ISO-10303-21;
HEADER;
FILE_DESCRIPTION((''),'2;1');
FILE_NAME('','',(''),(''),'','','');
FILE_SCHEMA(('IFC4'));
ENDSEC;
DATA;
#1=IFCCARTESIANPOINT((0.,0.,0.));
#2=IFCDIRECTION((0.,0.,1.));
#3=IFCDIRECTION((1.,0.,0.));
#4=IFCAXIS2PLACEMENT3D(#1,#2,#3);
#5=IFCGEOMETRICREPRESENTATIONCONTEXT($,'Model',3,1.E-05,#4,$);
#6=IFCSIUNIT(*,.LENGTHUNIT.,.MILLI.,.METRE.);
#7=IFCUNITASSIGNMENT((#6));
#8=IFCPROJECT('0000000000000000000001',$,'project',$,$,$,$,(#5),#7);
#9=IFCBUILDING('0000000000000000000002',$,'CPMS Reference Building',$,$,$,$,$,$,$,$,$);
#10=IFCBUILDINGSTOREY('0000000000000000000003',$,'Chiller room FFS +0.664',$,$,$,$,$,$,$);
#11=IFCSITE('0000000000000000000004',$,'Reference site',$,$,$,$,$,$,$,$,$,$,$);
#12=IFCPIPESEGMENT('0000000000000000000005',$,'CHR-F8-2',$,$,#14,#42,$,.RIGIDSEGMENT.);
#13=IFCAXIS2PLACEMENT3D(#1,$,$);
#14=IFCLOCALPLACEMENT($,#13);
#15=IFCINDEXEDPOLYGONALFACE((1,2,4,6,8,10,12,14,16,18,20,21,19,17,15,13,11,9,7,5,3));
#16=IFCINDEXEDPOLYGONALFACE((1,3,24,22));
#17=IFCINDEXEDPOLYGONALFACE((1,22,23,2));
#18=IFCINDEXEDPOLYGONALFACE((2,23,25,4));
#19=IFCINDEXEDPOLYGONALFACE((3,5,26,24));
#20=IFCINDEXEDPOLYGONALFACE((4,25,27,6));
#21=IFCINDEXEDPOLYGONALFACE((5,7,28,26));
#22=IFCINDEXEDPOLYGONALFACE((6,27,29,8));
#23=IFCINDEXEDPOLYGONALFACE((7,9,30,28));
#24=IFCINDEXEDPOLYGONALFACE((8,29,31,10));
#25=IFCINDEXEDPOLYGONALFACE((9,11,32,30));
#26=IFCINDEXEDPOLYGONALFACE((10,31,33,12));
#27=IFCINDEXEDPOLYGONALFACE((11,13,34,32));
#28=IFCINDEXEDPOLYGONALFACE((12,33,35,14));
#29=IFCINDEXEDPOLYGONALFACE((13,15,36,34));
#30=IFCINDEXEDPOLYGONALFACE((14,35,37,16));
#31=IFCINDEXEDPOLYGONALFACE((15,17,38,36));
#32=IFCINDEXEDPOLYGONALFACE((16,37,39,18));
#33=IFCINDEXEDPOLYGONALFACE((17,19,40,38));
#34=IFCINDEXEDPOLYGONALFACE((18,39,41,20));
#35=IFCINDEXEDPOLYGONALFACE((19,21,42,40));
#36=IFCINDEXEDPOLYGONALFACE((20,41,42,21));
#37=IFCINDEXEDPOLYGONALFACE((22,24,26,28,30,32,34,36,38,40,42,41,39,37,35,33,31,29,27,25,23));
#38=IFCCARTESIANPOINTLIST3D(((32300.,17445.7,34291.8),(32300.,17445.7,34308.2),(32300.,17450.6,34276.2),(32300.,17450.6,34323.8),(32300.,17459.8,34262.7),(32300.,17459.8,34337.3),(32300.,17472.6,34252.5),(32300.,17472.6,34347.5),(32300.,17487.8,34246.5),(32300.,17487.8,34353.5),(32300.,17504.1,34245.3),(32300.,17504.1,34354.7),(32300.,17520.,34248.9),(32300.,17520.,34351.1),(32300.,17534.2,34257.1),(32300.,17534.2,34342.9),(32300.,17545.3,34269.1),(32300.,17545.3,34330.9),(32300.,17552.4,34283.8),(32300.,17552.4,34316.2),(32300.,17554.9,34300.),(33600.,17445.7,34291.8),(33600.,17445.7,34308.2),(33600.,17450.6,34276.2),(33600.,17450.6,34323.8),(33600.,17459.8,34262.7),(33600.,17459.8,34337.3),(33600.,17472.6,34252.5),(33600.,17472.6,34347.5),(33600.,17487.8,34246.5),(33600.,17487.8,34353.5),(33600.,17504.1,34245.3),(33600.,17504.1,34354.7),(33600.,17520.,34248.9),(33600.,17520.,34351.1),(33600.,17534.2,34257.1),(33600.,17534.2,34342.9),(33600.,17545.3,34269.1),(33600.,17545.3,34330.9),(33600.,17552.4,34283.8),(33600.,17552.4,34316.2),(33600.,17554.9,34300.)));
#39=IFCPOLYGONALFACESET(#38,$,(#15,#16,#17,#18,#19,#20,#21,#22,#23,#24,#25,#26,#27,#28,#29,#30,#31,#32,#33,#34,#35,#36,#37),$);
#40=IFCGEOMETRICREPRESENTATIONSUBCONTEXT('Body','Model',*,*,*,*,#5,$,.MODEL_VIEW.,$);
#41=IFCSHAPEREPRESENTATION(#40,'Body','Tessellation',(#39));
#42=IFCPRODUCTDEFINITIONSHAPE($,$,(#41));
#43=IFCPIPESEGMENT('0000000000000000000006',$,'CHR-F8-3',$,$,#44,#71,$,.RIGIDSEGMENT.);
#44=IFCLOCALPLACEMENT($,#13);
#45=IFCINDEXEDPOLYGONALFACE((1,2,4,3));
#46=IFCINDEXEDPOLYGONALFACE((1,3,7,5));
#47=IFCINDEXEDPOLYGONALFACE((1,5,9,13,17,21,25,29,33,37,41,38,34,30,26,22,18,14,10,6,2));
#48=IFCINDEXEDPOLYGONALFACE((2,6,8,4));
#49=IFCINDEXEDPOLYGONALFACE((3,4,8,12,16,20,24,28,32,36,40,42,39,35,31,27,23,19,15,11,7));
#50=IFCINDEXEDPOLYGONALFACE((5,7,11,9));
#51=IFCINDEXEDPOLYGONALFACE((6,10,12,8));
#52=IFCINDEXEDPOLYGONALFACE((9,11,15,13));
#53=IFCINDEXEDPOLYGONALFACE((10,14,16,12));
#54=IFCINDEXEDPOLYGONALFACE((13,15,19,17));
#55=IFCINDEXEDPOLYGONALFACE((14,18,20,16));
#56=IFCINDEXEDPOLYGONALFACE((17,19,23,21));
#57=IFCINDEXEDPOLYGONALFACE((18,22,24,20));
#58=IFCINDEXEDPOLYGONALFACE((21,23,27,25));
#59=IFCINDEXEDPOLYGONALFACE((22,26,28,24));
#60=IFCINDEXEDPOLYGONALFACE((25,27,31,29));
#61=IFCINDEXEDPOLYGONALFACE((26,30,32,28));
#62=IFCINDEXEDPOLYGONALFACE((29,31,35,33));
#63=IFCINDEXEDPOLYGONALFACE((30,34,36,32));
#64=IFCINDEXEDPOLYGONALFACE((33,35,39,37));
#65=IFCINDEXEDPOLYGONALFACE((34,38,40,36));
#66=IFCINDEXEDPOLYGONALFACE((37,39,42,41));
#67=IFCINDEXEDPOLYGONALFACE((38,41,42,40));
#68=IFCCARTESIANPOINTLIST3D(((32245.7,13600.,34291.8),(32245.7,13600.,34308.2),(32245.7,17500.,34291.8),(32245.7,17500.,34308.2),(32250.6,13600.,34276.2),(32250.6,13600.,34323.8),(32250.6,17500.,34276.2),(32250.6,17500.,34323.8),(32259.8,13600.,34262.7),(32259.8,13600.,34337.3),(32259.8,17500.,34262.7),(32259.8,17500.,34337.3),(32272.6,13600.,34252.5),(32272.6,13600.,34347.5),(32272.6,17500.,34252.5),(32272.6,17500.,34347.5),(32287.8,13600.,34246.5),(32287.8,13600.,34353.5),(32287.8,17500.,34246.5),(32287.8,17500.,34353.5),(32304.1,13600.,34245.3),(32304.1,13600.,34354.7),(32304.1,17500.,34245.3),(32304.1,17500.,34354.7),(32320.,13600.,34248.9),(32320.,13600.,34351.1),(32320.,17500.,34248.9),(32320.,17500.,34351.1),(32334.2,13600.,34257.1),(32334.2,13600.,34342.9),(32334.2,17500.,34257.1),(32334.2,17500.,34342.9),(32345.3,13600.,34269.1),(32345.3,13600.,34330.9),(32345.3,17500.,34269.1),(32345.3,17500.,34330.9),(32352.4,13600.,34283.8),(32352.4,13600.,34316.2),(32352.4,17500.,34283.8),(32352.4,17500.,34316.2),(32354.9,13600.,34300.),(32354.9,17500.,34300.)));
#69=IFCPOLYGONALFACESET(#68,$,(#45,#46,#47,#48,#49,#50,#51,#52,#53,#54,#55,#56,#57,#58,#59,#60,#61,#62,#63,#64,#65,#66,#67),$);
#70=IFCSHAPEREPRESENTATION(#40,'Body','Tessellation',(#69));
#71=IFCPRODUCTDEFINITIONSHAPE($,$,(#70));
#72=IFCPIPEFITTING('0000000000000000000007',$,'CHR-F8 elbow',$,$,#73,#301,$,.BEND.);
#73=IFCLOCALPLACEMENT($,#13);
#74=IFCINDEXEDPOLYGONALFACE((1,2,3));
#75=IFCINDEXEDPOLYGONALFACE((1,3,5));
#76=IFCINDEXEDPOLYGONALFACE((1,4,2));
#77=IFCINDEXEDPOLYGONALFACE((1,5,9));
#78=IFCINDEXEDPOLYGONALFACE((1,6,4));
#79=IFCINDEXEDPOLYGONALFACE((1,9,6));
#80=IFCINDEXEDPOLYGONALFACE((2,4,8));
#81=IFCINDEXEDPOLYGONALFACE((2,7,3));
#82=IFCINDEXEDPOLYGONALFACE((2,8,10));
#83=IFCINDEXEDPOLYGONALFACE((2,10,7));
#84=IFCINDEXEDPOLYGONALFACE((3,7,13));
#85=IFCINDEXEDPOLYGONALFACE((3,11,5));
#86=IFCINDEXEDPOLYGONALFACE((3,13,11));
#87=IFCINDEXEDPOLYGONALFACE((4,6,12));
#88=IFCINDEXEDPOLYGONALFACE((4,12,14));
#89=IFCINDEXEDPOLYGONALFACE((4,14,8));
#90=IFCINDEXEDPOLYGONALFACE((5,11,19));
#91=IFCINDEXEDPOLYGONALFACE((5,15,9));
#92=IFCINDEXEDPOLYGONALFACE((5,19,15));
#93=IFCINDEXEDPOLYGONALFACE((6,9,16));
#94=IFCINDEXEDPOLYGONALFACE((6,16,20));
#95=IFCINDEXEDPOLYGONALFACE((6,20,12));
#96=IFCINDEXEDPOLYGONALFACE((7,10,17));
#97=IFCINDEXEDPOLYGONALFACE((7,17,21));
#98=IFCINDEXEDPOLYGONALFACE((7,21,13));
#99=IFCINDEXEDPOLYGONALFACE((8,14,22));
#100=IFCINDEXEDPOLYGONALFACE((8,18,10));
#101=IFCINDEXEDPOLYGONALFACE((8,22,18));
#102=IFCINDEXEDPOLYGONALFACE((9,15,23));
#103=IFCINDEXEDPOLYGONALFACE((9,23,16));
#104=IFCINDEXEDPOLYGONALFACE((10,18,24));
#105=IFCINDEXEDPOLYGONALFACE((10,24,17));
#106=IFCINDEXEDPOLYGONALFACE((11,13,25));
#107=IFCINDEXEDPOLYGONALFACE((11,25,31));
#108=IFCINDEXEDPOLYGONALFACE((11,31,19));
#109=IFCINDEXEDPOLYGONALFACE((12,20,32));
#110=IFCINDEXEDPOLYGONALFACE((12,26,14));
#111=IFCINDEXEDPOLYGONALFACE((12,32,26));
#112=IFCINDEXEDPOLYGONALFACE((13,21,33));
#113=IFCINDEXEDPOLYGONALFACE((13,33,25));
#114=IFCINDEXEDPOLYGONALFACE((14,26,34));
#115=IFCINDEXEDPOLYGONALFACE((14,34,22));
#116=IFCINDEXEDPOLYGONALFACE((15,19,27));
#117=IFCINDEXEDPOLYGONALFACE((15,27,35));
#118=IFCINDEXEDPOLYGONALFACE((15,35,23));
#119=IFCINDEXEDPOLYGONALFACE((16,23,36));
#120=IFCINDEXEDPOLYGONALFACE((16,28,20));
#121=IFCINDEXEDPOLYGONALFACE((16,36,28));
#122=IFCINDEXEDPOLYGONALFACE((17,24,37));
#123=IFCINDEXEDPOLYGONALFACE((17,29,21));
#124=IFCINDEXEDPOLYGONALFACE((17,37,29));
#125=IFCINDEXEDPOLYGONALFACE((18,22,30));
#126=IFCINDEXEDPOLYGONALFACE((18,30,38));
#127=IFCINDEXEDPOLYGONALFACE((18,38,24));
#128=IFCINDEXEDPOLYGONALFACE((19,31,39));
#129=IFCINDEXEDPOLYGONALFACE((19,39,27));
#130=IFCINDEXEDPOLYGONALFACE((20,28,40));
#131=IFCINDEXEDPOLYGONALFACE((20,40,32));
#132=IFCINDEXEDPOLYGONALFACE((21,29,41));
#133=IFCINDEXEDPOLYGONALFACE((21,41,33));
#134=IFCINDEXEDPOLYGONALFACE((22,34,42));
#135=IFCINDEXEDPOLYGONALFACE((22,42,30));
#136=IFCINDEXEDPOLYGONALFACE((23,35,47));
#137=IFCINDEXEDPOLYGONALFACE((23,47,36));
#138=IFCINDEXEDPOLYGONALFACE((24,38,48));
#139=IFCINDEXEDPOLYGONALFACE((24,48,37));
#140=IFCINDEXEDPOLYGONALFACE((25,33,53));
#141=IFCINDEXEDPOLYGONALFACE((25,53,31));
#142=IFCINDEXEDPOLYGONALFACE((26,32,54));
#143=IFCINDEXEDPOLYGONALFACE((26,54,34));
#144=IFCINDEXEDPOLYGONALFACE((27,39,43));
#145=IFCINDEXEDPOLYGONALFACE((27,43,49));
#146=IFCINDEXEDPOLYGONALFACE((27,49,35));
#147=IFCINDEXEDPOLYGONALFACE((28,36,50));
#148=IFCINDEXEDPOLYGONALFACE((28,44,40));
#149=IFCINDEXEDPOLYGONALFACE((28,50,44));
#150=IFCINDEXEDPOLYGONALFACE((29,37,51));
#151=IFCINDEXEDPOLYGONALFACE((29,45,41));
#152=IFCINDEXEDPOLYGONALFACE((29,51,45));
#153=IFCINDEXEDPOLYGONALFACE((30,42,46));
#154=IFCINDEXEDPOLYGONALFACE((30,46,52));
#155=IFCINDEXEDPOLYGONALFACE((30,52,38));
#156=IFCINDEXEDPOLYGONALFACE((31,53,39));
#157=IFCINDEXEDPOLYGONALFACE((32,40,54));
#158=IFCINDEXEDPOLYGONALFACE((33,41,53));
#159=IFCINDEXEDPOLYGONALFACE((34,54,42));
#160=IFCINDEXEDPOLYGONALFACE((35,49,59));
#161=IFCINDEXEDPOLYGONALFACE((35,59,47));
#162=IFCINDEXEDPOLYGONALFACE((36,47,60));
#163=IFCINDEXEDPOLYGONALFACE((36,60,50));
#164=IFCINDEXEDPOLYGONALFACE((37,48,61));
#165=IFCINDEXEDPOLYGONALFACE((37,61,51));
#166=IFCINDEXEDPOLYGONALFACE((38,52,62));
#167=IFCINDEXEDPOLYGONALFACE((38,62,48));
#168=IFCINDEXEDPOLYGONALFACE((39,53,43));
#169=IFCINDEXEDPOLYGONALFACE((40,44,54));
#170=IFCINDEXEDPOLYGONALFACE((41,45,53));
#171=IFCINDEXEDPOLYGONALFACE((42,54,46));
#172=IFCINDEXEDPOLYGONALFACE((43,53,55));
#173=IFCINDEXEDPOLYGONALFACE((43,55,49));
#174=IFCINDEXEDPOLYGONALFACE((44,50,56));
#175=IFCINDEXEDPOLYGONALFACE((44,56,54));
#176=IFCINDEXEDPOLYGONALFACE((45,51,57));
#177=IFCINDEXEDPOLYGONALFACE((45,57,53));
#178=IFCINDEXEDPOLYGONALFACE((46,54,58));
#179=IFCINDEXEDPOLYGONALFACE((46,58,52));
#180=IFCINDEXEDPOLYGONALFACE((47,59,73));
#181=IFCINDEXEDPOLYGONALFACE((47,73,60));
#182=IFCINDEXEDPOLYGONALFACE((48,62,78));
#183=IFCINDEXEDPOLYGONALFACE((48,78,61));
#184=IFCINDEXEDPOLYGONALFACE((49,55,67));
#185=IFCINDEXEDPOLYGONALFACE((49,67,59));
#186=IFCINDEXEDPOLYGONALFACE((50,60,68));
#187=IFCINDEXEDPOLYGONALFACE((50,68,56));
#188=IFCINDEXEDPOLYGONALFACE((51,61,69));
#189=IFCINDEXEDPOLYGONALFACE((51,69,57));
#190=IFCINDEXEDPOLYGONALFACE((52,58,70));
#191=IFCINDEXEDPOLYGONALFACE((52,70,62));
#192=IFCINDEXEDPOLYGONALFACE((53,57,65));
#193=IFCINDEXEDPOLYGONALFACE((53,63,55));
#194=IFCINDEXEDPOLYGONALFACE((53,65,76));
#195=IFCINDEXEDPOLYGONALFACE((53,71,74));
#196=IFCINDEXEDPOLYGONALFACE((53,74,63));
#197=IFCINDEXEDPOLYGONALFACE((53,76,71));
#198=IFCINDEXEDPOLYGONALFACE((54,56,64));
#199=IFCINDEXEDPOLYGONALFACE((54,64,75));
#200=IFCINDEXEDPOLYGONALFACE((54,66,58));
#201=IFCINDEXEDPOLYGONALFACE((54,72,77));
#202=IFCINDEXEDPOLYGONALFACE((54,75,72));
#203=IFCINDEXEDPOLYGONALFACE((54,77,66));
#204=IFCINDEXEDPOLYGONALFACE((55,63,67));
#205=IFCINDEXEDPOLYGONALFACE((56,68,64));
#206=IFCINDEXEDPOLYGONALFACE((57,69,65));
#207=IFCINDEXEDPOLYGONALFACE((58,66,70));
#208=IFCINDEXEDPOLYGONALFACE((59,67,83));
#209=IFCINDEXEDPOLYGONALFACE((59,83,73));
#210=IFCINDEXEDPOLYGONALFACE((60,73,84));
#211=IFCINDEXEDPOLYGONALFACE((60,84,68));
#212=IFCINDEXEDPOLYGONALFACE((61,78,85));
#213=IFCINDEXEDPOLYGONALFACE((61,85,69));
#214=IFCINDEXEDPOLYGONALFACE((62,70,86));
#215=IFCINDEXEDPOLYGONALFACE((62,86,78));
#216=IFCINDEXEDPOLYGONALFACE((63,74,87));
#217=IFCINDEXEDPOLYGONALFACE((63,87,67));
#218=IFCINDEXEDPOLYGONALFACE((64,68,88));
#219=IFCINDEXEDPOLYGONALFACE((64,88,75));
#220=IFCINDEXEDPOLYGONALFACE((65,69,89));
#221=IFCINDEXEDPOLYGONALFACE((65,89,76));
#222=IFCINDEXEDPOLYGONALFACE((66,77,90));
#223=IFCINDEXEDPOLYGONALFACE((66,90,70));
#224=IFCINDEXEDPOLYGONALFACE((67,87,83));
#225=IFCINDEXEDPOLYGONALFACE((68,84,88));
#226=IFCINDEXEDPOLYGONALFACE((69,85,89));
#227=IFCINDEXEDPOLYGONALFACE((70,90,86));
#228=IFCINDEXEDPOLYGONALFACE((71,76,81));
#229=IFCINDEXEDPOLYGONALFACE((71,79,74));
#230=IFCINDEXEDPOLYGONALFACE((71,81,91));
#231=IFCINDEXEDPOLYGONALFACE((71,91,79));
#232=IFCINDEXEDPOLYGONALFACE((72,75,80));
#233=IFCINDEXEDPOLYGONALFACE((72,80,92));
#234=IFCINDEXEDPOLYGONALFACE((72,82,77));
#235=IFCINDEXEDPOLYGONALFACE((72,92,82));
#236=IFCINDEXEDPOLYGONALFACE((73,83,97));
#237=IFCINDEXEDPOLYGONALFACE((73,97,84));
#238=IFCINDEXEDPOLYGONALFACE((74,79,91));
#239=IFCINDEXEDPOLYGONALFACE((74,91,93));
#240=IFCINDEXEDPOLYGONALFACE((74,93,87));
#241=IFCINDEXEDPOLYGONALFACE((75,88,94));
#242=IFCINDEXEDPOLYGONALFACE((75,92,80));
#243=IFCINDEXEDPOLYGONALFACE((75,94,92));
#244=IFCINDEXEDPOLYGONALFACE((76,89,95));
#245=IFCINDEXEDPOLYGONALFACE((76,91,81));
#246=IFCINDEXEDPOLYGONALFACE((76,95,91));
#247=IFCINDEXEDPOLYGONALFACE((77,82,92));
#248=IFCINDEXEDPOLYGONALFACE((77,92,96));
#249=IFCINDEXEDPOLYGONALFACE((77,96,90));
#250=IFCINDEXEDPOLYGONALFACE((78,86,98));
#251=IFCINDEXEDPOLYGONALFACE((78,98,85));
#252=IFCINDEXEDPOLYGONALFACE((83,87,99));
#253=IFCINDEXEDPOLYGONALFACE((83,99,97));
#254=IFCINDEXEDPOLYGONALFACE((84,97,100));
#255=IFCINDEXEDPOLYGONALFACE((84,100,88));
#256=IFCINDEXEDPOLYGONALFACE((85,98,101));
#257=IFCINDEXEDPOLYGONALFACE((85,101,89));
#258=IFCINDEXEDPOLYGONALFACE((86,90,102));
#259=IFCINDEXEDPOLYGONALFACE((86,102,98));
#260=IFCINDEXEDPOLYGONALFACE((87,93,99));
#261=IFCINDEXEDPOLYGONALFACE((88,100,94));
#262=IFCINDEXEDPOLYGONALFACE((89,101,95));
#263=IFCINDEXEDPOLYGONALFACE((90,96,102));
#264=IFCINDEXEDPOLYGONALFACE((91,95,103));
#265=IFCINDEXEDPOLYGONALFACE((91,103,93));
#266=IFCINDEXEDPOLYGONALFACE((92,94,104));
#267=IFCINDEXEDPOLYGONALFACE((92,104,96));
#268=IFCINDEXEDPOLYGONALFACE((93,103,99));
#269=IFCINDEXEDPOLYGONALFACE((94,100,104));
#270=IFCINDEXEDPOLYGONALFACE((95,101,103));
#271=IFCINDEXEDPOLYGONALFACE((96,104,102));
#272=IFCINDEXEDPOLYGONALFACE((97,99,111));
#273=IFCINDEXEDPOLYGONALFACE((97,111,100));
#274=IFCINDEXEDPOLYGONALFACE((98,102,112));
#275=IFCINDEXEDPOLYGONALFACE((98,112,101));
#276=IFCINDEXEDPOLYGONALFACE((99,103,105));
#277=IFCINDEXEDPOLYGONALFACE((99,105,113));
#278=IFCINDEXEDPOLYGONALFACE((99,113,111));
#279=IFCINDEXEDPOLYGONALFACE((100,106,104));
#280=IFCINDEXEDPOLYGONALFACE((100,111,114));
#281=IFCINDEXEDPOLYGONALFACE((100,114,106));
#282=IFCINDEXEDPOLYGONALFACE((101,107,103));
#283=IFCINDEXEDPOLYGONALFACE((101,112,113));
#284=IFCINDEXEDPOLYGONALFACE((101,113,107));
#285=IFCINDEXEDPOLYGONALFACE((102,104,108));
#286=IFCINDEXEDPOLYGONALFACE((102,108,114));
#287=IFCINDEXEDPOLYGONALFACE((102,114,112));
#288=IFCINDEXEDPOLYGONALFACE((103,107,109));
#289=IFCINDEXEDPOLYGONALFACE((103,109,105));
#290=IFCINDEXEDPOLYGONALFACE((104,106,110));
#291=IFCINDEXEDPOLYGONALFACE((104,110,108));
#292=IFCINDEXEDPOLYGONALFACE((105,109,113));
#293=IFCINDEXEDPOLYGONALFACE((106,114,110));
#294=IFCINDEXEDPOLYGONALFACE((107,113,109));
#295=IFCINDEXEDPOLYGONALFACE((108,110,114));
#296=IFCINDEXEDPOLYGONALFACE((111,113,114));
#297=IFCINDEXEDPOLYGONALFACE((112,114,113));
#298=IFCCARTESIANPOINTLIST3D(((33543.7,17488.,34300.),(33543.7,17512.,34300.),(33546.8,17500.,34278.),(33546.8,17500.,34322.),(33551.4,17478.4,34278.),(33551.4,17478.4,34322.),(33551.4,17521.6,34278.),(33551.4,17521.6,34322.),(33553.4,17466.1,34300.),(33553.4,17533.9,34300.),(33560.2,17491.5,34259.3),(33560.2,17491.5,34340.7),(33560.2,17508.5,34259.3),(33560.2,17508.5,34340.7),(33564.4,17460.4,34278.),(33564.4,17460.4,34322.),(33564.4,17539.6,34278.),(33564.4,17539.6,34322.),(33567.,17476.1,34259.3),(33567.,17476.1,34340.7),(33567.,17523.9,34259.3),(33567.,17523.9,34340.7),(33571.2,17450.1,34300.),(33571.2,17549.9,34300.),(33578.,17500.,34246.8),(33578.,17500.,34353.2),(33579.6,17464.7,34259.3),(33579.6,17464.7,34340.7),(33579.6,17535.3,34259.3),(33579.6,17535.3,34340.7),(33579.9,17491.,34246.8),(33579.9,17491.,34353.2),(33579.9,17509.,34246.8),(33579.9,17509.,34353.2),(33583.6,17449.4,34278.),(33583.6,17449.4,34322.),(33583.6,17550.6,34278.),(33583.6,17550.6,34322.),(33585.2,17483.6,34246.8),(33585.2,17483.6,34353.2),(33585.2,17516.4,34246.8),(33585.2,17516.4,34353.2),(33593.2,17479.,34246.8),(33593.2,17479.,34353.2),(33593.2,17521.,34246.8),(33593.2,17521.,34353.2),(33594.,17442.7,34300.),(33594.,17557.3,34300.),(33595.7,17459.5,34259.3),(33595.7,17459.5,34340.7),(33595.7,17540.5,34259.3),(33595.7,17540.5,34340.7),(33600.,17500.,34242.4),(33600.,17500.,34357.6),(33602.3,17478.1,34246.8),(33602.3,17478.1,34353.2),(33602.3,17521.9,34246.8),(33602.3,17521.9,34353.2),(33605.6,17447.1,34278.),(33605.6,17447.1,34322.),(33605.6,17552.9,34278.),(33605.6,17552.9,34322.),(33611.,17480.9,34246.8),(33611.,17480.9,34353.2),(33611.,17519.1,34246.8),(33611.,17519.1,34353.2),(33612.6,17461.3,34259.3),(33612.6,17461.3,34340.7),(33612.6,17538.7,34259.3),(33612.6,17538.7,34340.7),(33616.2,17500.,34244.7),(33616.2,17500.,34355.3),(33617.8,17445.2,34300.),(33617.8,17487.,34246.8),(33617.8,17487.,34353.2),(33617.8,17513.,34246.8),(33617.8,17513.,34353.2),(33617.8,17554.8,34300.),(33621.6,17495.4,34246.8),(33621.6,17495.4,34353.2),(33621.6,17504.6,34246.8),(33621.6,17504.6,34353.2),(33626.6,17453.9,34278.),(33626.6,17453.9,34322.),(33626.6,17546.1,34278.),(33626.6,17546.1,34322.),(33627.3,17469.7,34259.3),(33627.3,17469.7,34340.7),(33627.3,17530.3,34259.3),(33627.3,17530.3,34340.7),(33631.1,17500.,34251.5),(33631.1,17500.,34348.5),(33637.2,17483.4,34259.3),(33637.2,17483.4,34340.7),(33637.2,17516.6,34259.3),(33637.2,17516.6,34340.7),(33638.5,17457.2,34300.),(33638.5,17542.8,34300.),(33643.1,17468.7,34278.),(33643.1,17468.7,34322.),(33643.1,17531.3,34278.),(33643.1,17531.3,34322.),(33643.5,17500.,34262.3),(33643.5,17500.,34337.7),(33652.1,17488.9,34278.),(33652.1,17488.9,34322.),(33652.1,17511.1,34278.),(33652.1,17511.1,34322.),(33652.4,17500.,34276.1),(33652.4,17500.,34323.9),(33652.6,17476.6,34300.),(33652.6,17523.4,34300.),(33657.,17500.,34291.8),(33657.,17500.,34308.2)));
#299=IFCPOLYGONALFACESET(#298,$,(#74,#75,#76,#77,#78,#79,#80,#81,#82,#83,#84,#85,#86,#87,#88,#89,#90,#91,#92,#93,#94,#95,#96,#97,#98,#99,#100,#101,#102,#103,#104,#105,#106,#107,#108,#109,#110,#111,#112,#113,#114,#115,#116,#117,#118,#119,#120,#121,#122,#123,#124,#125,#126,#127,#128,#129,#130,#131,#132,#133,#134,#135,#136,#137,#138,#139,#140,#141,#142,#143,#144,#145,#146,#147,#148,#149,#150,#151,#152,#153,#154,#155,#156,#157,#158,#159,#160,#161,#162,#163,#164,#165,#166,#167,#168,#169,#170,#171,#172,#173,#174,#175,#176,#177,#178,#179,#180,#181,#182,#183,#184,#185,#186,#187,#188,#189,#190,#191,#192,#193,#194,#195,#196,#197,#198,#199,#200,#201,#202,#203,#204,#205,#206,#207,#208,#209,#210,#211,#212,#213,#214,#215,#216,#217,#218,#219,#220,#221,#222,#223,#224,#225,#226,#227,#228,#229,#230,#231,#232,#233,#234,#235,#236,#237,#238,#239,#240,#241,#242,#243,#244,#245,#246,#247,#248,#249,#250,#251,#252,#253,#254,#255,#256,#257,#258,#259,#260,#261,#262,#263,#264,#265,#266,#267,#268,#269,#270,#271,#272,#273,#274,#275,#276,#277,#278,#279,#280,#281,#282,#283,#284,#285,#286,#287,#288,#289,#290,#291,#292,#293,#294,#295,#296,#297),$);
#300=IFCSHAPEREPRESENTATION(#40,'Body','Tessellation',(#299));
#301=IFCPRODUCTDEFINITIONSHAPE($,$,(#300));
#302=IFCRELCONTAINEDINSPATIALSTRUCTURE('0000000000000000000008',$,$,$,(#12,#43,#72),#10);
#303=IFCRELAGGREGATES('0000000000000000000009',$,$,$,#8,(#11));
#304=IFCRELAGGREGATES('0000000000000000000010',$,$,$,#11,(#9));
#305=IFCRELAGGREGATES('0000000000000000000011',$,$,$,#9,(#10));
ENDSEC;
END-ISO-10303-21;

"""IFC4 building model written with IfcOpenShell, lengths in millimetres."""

from ifc_helpers import new_model, entity, si_unit, frame, origin_with_axes, origin_2d, place, context, subcontext, project, spatial, circle_curve, outline, extrude, element, save


model = new_model("IFC4")

# Units and contexts
model_context = context("Model", 3, precision=1e-05, world=origin_with_axes())
body_context = subcontext(model_context, "Body", "Model", "MODEL_VIEW")
ifc_project = project(units=[si_unit("LENGTHUNIT", "METRE", prefix="MILLI")], contexts=[model_context])

# Site, building, storey
site = spatial("IfcSite", under=ifc_project, Name="Reference site")
building = spatial("IfcBuilding", under=site, Name="CPMS Reference Building")
storey = spatial("IfcBuildingStorey", under=building, Name="Chiller room FFS +0.664")

# Pipe segments
pipe_segment_1_placement = place(None, origin_with_axes())
element("IfcPipeSegment", 1, at=pipe_segment_1_placement, inside=storey, Name="CHR-F8-2", PredefinedType="RIGIDSEGMENT", context=body_context, shape_type="SweptSolid", body=[
    extrude(outline(circle_curve(origin_2d(), 54.9)), frame((33600.0, 17500.0, 34300.0), z_axis=(-1.0, 0.0, 0.0), x_axis=(0.0, 1.0, 0.0)), (0.0, 0.0, 1.0), 1300.0),
])
pipe_segment_2_placement = place(None, origin_with_axes())
element("IfcPipeSegment", 2, at=pipe_segment_2_placement, inside=storey, Name="CHR-F8-3", PredefinedType="RIGIDSEGMENT", context=body_context, shape_type="SweptSolid", body=[
    extrude(outline(circle_curve(origin_2d(), 54.9)), frame((32300.0, 17500.0, 34300.0), z_axis=(0.0, -1.0, 0.0), x_axis=(1.0, 0.0, 0.0)), (0.0, 0.0, 1.0), 3900.0),
])

# Pipe fitting
pipe_fitting_1_placement = place(None, origin_with_axes())
element("IfcPipeFitting", 3, at=pipe_fitting_1_placement, inside=storey, Name="CHR-F8 elbow", PredefinedType="BEND", context=body_context, shape_type="CSG", body=[
    entity("IfcSphere", entity("IfcAxis2Placement3D", entity("IfcCartesianPoint", [33600.0, 17500.0, 34300.0]), entity("IfcDirection", [0.0, 0.0, 1.0]), entity("IfcDirection", [1.0, 0.0, 0.0])), 57.6),
])

save(model, "model.ifc")
